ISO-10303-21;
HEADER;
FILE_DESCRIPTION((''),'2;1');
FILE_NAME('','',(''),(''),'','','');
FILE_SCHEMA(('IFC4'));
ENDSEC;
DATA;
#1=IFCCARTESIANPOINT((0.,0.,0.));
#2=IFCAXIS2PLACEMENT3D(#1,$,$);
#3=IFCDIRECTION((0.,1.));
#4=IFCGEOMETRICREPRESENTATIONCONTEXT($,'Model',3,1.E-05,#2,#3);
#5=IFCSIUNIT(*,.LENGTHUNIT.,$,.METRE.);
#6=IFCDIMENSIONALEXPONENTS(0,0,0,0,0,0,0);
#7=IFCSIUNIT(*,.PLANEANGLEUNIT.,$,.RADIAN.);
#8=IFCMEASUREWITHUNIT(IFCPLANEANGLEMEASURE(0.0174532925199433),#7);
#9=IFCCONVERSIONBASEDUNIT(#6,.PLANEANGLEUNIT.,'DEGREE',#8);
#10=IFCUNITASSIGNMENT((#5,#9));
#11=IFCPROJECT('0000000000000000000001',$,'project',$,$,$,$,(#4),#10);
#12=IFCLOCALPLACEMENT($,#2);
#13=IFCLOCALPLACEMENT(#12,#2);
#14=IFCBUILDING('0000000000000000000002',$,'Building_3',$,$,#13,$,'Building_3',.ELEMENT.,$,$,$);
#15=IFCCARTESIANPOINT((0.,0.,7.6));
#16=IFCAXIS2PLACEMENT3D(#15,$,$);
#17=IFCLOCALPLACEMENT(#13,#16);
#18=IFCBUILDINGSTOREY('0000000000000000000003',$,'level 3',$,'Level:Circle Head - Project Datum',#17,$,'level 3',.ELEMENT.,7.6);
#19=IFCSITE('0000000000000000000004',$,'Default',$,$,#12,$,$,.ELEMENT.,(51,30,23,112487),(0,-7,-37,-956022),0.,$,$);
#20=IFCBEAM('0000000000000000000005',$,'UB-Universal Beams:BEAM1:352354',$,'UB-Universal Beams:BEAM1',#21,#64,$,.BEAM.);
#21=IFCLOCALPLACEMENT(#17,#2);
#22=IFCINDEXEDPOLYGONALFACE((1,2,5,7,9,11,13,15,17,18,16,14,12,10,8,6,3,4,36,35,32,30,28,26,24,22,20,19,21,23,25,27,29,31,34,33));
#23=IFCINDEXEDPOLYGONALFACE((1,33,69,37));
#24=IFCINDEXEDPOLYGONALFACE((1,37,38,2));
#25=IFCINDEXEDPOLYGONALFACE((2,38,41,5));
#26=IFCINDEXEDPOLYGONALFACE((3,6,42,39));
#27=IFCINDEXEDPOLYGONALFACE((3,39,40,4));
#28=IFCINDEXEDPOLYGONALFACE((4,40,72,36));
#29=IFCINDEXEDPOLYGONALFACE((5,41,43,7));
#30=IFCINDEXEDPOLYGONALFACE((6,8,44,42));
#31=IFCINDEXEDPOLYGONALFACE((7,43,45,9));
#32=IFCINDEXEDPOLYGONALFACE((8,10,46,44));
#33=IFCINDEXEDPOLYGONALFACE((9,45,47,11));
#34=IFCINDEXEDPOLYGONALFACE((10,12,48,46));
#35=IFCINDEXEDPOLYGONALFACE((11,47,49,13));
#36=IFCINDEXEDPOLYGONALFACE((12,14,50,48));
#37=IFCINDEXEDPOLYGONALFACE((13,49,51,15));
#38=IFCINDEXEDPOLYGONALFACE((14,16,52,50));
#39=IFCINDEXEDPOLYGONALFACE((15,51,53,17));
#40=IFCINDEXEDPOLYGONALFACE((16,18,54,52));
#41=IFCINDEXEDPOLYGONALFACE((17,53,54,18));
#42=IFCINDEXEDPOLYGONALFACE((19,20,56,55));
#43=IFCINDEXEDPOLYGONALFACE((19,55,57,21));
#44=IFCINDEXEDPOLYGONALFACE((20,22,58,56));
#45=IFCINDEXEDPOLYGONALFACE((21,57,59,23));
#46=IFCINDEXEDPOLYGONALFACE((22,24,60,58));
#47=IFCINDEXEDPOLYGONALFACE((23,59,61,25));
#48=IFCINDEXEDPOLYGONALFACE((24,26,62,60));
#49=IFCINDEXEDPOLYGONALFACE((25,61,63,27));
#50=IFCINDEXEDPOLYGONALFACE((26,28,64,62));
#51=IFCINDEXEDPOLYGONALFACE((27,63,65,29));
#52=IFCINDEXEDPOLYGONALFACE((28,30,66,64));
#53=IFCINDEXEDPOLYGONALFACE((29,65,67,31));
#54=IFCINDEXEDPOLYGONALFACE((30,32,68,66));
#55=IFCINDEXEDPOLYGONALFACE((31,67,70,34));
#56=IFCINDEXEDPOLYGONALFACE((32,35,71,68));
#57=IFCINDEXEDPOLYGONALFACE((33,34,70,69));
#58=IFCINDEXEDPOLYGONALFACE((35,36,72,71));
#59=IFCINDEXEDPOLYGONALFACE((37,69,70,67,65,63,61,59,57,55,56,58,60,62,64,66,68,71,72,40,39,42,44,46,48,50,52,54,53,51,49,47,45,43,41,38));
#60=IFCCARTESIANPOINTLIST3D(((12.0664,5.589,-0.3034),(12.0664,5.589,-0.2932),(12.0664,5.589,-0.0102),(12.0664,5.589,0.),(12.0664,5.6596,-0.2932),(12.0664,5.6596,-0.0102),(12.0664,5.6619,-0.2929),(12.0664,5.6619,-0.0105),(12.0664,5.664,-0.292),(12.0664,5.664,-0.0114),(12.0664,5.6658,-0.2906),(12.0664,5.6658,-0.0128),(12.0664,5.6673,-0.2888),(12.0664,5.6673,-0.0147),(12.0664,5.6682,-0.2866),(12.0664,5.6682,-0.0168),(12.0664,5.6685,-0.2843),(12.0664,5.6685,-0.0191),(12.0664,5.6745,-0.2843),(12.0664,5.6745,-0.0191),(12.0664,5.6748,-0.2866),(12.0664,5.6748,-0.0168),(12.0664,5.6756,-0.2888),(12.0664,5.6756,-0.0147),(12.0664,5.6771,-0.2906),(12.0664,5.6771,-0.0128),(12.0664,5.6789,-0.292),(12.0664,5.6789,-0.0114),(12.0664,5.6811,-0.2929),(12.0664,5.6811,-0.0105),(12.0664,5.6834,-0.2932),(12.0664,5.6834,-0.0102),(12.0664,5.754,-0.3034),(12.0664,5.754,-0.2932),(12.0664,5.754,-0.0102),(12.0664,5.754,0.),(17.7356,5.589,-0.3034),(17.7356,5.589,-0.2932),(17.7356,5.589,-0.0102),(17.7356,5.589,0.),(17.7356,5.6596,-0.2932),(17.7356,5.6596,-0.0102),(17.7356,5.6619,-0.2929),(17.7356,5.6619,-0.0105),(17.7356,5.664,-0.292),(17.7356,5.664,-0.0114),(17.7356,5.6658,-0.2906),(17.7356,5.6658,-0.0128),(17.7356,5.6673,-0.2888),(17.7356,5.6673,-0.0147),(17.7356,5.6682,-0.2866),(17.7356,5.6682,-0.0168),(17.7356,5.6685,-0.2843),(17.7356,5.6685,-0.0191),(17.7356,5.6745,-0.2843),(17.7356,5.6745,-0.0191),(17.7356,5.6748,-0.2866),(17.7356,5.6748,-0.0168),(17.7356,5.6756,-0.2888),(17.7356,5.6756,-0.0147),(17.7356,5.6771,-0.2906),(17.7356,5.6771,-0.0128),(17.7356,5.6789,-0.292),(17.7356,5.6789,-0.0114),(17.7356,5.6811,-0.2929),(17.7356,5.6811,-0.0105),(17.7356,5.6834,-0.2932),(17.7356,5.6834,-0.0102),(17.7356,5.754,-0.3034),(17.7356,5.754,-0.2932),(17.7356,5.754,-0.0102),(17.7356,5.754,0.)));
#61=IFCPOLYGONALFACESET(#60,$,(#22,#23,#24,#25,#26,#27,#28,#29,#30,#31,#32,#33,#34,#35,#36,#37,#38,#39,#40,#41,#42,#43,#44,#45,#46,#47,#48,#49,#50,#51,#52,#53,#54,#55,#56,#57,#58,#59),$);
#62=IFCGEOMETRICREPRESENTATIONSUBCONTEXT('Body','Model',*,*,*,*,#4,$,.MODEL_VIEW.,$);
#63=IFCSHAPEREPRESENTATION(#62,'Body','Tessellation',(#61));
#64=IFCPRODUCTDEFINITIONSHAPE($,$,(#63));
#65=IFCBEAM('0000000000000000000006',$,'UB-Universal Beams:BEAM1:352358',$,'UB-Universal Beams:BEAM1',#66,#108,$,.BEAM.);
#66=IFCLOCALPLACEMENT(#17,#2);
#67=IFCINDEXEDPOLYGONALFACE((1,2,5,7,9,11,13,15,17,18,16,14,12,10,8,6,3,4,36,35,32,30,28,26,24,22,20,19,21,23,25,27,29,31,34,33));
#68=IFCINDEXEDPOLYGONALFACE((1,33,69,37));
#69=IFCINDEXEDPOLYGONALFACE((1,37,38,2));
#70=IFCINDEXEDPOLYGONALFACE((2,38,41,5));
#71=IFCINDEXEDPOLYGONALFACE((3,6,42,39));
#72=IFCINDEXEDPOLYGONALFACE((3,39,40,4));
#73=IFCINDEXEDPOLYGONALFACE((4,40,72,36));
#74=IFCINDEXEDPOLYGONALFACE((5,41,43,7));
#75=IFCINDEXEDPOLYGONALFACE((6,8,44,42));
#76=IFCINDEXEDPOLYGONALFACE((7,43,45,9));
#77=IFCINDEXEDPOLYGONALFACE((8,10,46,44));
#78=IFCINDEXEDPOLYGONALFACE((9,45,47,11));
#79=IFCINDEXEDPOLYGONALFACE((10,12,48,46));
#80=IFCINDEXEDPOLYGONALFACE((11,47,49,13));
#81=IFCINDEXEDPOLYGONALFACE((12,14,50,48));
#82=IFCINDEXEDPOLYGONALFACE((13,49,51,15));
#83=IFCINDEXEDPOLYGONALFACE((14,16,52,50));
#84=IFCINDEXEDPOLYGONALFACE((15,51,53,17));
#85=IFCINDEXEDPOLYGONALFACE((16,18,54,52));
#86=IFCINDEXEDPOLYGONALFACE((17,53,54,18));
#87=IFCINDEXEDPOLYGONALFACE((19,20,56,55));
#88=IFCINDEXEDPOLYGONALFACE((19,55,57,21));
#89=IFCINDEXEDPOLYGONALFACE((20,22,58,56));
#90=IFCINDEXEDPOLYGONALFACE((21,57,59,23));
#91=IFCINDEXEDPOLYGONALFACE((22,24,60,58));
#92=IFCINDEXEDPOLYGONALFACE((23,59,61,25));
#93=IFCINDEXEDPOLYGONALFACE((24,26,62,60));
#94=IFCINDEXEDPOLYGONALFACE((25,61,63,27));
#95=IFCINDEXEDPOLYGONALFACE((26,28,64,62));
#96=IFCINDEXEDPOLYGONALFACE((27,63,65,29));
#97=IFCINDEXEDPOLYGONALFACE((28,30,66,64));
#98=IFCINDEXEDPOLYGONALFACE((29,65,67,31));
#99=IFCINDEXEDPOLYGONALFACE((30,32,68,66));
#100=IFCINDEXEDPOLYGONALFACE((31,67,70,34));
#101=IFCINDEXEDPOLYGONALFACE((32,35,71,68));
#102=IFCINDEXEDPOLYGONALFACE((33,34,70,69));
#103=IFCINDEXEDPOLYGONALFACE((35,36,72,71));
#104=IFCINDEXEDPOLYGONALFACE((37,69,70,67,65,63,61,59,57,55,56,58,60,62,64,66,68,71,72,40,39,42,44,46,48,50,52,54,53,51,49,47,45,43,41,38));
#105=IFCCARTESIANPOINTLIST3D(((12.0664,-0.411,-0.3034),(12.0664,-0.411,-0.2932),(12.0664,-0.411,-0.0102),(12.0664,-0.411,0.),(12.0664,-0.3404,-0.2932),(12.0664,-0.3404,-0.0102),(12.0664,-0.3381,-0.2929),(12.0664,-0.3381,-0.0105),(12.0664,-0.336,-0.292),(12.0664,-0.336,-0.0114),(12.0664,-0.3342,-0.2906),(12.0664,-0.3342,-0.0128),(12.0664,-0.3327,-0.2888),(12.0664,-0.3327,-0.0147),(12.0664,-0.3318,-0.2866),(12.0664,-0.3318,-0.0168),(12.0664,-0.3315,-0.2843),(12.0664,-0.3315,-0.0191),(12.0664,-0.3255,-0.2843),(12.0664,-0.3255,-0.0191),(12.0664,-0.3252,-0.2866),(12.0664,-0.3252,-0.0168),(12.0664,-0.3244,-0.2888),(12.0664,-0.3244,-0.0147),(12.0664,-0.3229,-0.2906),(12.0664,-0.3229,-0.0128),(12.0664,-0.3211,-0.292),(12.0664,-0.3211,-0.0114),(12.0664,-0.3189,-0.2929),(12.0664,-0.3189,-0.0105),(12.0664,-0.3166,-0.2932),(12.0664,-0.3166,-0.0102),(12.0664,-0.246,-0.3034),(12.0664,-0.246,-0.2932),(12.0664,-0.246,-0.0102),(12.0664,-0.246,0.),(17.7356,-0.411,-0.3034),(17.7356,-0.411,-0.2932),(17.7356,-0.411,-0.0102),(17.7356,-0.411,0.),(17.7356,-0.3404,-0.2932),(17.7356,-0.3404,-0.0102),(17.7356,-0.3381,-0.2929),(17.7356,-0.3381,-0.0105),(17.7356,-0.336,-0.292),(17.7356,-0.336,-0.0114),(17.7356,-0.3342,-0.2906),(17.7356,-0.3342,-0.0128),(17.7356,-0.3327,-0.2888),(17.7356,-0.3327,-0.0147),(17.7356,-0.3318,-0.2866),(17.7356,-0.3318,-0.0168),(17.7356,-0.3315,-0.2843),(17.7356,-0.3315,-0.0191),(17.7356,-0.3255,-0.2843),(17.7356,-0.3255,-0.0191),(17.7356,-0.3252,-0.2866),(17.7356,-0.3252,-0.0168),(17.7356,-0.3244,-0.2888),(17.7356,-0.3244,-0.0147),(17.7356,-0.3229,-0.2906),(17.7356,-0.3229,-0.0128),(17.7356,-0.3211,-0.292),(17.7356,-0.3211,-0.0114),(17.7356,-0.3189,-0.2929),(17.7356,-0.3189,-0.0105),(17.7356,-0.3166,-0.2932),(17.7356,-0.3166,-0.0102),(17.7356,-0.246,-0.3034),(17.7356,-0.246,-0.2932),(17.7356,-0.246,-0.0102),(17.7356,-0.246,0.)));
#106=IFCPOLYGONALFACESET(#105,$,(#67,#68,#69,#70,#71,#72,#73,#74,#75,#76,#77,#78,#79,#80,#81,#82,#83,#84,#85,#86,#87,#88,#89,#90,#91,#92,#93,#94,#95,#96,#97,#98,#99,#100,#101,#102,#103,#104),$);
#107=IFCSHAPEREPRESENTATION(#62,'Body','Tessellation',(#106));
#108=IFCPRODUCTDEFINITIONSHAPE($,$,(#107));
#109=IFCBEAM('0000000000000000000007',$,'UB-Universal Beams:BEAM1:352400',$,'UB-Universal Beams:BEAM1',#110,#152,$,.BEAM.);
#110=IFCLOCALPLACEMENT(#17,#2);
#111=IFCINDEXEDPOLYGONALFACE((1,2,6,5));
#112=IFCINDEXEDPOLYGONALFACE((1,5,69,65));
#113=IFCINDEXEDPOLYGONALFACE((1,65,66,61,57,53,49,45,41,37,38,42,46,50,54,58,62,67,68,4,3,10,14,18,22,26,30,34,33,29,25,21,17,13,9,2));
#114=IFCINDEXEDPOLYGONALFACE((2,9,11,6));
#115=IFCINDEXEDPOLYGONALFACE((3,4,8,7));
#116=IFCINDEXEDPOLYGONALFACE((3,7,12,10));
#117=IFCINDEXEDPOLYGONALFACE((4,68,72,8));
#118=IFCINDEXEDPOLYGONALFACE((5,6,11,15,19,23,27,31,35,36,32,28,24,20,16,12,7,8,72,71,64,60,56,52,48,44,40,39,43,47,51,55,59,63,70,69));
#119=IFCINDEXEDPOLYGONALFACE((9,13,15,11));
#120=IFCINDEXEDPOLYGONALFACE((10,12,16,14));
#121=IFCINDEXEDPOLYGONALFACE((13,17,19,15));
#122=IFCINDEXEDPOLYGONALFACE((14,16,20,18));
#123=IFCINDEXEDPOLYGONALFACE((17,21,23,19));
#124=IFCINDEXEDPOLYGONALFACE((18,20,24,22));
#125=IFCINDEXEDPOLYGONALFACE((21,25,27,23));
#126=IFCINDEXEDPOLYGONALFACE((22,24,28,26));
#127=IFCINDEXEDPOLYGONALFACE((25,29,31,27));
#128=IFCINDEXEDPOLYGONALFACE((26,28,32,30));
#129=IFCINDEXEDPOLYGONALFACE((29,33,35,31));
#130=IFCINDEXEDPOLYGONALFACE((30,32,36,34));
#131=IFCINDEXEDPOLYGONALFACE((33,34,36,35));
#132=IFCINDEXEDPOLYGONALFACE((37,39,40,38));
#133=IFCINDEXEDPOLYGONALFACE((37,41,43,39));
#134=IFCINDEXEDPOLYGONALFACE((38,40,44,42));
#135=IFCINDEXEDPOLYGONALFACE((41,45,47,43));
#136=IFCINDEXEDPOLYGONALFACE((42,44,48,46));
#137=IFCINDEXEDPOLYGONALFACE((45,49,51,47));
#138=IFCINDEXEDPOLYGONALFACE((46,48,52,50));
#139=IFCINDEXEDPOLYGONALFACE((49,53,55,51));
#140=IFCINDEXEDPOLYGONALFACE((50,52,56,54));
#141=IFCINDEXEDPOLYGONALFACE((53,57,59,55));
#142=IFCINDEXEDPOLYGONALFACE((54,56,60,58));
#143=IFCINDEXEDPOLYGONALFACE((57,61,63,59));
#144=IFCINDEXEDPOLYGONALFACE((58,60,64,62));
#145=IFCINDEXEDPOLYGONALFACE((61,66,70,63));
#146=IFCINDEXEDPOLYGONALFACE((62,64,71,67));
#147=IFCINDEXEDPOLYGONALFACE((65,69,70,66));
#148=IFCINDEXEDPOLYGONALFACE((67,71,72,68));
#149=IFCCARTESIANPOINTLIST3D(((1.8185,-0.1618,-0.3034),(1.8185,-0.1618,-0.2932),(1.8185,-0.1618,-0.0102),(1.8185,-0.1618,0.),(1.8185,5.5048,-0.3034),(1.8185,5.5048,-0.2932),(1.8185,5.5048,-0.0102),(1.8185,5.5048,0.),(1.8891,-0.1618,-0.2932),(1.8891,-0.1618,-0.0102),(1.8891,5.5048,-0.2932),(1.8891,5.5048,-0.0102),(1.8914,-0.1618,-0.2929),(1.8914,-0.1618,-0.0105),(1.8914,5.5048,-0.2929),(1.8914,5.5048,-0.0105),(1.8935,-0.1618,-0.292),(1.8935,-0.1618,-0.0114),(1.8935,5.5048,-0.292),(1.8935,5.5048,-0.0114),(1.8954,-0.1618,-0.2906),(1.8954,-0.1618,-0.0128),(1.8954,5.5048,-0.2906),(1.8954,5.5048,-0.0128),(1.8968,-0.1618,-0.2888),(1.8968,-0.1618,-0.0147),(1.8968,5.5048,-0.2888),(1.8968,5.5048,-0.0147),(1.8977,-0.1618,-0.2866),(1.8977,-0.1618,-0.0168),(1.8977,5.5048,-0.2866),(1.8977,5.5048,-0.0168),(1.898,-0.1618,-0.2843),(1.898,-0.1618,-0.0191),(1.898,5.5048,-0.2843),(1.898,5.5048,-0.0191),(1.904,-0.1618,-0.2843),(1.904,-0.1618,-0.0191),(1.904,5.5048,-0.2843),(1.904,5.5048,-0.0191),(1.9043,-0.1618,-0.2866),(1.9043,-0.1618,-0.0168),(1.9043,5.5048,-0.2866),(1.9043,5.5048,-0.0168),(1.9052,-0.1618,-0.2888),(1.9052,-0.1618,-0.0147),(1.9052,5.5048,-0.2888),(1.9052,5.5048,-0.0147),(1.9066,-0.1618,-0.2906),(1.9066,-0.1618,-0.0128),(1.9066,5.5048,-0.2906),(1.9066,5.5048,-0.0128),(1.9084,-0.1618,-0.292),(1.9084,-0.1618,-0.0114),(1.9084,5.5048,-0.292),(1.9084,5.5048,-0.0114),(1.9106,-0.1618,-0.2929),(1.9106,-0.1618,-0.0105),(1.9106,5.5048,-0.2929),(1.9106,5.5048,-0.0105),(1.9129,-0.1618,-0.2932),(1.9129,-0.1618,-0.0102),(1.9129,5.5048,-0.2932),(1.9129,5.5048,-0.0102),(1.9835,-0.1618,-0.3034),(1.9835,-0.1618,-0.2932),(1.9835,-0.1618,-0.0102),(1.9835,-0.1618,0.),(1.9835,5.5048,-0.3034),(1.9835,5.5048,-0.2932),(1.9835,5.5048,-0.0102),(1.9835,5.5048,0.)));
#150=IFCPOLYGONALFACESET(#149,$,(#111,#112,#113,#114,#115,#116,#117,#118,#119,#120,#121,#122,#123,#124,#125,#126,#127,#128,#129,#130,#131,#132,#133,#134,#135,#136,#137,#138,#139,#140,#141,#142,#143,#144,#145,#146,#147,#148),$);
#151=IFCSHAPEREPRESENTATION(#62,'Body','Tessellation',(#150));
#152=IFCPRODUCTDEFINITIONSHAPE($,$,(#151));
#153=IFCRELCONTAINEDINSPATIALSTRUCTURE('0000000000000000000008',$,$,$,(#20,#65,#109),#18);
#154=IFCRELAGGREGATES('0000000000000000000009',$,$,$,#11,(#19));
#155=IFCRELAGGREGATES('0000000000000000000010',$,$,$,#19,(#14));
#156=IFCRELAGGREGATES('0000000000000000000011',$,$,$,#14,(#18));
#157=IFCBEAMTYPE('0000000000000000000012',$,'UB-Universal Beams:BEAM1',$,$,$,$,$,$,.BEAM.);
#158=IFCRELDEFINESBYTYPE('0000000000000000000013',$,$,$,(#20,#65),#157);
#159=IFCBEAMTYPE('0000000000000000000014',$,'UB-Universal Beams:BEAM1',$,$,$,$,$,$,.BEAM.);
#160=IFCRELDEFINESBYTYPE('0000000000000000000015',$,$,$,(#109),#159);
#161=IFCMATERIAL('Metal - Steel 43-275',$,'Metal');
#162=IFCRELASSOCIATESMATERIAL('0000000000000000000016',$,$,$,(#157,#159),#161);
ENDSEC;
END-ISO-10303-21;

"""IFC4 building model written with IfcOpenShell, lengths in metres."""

from ifc_helpers import new_model, entity, si_unit, converted_unit, direction, frame, frame_2d, origin, place, context, subcontext, project, spatial, polyline, circle_curve, parameter, trimmed, segment, composite_curve, outline, extrude, source, transform, mapped, material, material_profile, profile_set, type_object, type_shapes, element, save


model = new_model("IFC4")

# Units and contexts
model_context = context("Model", 3, precision=1e-05, world=origin(), true_north=direction((0.0, 1.0)))
body_context = subcontext(model_context, "Body", "Model", "MODEL_VIEW")
ifc_project = project(units=[si_unit("LENGTHUNIT", "METRE"), converted_unit("PLANEANGLEUNIT", "DEGREE", entity("IfcPlaneAngleMeasure", 0.0174532925199433), si_unit("PLANEANGLEUNIT", "RADIAN"), dimensions=[0, 0, 0, 0, 0, 0, 0])], contexts=[model_context])

# Site, building, storey
site_placement = place(None, origin())
site = spatial("IfcSite", under=ifc_project, at=site_placement, Name="Default", CompositionType="ELEMENT", RefLatitude=(51, 30, 23, 112487), RefLongitude=(0, -7, -37, -956022), RefElevation=0.0)
building_placement = place(site_placement, origin())
building = spatial("IfcBuilding", under=site, at=building_placement, Name="Building_3", LongName="Building_3", CompositionType="ELEMENT")
storey_placement = place(building_placement, frame((0.0, 0.0, 7.6)))
storey = spatial("IfcBuildingStorey", under=building, at=storey_placement, Name="level 3", ObjectType="Level:Circle Head - Project Datum", LongName="level 3", CompositionType="ELEMENT", Elevation=7.6)

# Shared definitions
ifc_material_1 = material(Name="Metal - Steel 43-275", Category="Metal")

# Beams
ifc_material_profile_1 = material_profile(ifc_material_1, outline(composite_curve([segment(polyline([(-0.0825, -0.1415), (-0.0825, -0.1517)]), True, "CONTINUOUS"), segment(polyline([(-0.0825, -0.1517), (0.0825, -0.1517)]), True, "CONTINUOUS"), segment(polyline([(0.0825, -0.1517), (0.0825, -0.1415)]), True, "CONTINUOUS"), segment(polyline([(0.0825, -0.1415), (0.0119, -0.1415)]), True, "CONTINUOUS"), segment(trimmed(circle_curve(frame_2d((0.0119, -0.1326), x_axis=(1.0, 0.0)), 0.0089), [parameter(180.0)], [parameter(270.0)], True, "PARAMETER"), False, "CONTINUOUS"), segment(polyline([(0.003, -0.1326), (0.003, 0.1326)]), True, "CONTINUOUS"), segment(trimmed(circle_curve(frame_2d((0.0119, 0.1326), x_axis=(1.0, 0.0)), 0.0089), [parameter(90.0)], [parameter(180.0)], True, "PARAMETER"), False, "CONTINUOUS"), segment(polyline([(0.0119, 0.1415), (0.0825, 0.1415)]), True, "CONTINUOUS"), segment(polyline([(0.0825, 0.1415), (0.0825, 0.1517)]), True, "CONTINUOUS"), segment(polyline([(0.0825, 0.1517), (-0.0825, 0.1517)]), True, "CONTINUOUS"), segment(polyline([(-0.0825, 0.1517), (-0.0825, 0.1415)]), True, "CONTINUOUS"), segment(polyline([(-0.0825, 0.1415), (-0.0119, 0.1415)]), True, "CONTINUOUS"), segment(trimmed(circle_curve(frame_2d((-0.0119, 0.1326), x_axis=(1.0, 0.0)), 0.0089), [parameter(360.0)], [parameter(90.0)], True, "PARAMETER"), False, "CONTINUOUS"), segment(polyline([(-0.003, 0.1326), (-0.003, -0.1326)]), True, "CONTINUOUS"), segment(trimmed(circle_curve(frame_2d((-0.0119, -0.1326), x_axis=(1.0, 0.0)), 0.0089), [parameter(270.0)], [parameter(360.0)], True, "PARAMETER"), False, "CONTINUOUS"), segment(polyline([(-0.0119, -0.1415), (-0.0825, -0.1415)]), True, "CONTINUOUS")], self_intersect=False)), Name="BEAM1")
ifc_profile_set_1 = profile_set([ifc_material_profile_1], Name="BEAM1")
beam_type_1 = type_object("IfcBeamType", Name="UB-Universal Beams:BEAM1", PredefinedType="BEAM", material=ifc_profile_set_1)
shared_shape_1 = source(origin(), body_context, "Body", "SweptSolid", [
    extrude(outline(composite_curve([segment(polyline([(-0.0825, -0.1415), (-0.0825, -0.1517)]), True, "CONTINUOUS"), segment(polyline([(-0.0825, -0.1517), (0.0825, -0.1517)]), True, "CONTINUOUS"), segment(polyline([(0.0825, -0.1517), (0.0825, -0.1415)]), True, "CONTINUOUS"), segment(polyline([(0.0825, -0.1415), (0.0119, -0.1415)]), True, "CONTINUOUS"), segment(trimmed(circle_curve(frame_2d((0.0119, -0.1326), x_axis=(0.0, -1.0)), 0.0089), [parameter(270.0)], [parameter(360.0)], True, "PARAMETER"), False, "CONTINUOUS"), segment(polyline([(0.003, -0.1326), (0.003, 0.1326)]), True, "CONTINUOUS"), segment(trimmed(circle_curve(frame_2d((0.0119, 0.1326), x_axis=(-1.0, 0.0)), 0.0089), [parameter(270.0)], [parameter(360.0)], True, "PARAMETER"), False, "CONTINUOUS"), segment(polyline([(0.0119, 0.1415), (0.0825, 0.1415)]), True, "CONTINUOUS"), segment(polyline([(0.0825, 0.1415), (0.0825, 0.1517)]), True, "CONTINUOUS"), segment(polyline([(0.0825, 0.1517), (-0.0825, 0.1517)]), True, "CONTINUOUS"), segment(polyline([(-0.0825, 0.1517), (-0.0825, 0.1415)]), True, "CONTINUOUS"), segment(polyline([(-0.0825, 0.1415), (-0.0119, 0.1415)]), True, "CONTINUOUS"), segment(trimmed(circle_curve(frame_2d((-0.0119, 0.1326), x_axis=(0.0, 1.0)), 0.0089), [parameter(270.0)], [parameter(360.0)], True, "PARAMETER"), False, "CONTINUOUS"), segment(polyline([(-0.003, 0.1326), (-0.003, -0.1326)]), True, "CONTINUOUS"), segment(trimmed(circle_curve(frame_2d((-0.0119, -0.1326), x_axis=(1.0, 0.0)), 0.0089), [parameter(270.0)], [parameter(0.0)], True, "PARAMETER"), False, "CONTINUOUS"), segment(polyline([(-0.0119, -0.1415), (-0.0825, -0.1415)]), True, "CONTINUOUS")], self_intersect=False)), frame((-2.8346, 0.0, 0.0), z_axis=(-1.0, 0.0, 0.0), x_axis=(0.0, -1.0, 0.0)), (0.0, 0.0, -1.0), 5.6692),
])
type_shapes(beam_type_1, [shared_shape_1])
for number, where, name in (
    (1, (14.901, 5.6715, -0.1517), "UB-Universal Beams:BEAM1:352354"),
    (2, (14.901, -0.3285, -0.1517), "UB-Universal Beams:BEAM1:352358"),
):
    element("IfcBeam", number, at=place(storey_placement, frame(where)), inside=storey, type_object=beam_type_1, Name=name, ObjectType="UB-Universal Beams:BEAM1", PredefinedType="BEAM", context=body_context, shape_type="MappedRepresentation", body=[
        mapped(shared_shape_1, transform((0.0, 0.0, 0.0), scale=1.0)),
    ])
beam_type_2 = type_object("IfcBeamType", Name="UB-Universal Beams:BEAM1", PredefinedType="BEAM", material=ifc_profile_set_1)
shared_shape_2 = source(origin(), body_context, "Body", "SweptSolid", [
    extrude(outline(composite_curve([segment(polyline([(-0.0825, -0.1415), (-0.0825, -0.1517)]), True, "CONTINUOUS"), segment(polyline([(-0.0825, -0.1517), (0.0825, -0.1517)]), True, "CONTINUOUS"), segment(polyline([(0.0825, -0.1517), (0.0825, -0.1415)]), True, "CONTINUOUS"), segment(polyline([(0.0825, -0.1415), (0.0119, -0.1415)]), True, "CONTINUOUS"), segment(trimmed(circle_curve(frame_2d((0.0119, -0.1326), x_axis=(1.0, 0.0)), 0.0089), [parameter(180.0)], [parameter(270.0)], True, "PARAMETER"), False, "CONTINUOUS"), segment(polyline([(0.003, -0.1326), (0.003, 0.1326)]), True, "CONTINUOUS"), segment(trimmed(circle_curve(frame_2d((0.0119, 0.1326), x_axis=(1.0, 0.0)), 0.0089), [parameter(90.0)], [parameter(180.0)], True, "PARAMETER"), False, "CONTINUOUS"), segment(polyline([(0.0119, 0.1415), (0.0825, 0.1415)]), True, "CONTINUOUS"), segment(polyline([(0.0825, 0.1415), (0.0825, 0.1517)]), True, "CONTINUOUS"), segment(polyline([(0.0825, 0.1517), (-0.0825, 0.1517)]), True, "CONTINUOUS"), segment(polyline([(-0.0825, 0.1517), (-0.0825, 0.1415)]), True, "CONTINUOUS"), segment(polyline([(-0.0825, 0.1415), (-0.0119, 0.1415)]), True, "CONTINUOUS"), segment(trimmed(circle_curve(frame_2d((-0.0119, 0.1326), x_axis=(1.0, 0.0)), 0.0089), [parameter(360.0)], [parameter(90.0)], True, "PARAMETER"), False, "CONTINUOUS"), segment(polyline([(-0.003, 0.1326), (-0.003, -0.1326)]), True, "CONTINUOUS"), segment(trimmed(circle_curve(frame_2d((-0.0119, -0.1326), x_axis=(1.0, 0.0)), 0.0089), [parameter(270.0)], [parameter(360.0)], True, "PARAMETER"), False, "CONTINUOUS"), segment(polyline([(-0.0119, -0.1415), (-0.0825, -0.1415)]), True, "CONTINUOUS")], self_intersect=False)), frame((-2.8333, 0.0, 0.0), z_axis=(-1.0, 0.0, 0.0), x_axis=(0.0, -1.0, 0.0)), (0.0, 0.0, -1.0), 5.6666),
])
type_shapes(beam_type_2, [shared_shape_2])
for number, where, z_axis, x_axis, name in (
    (3, (1.901, 2.6715, -0.1517), (0.0, 0.0, 1.0), (0.0, -1.0, 0.0), "UB-Universal Beams:BEAM1:352400"),
):
    element("IfcBeam", number, at=place(storey_placement, frame(where, z_axis=z_axis, x_axis=x_axis)), inside=storey, type_object=beam_type_2, Name=name, ObjectType="UB-Universal Beams:BEAM1", PredefinedType="BEAM", context=body_context, shape_type="MappedRepresentation", body=[
        mapped(shared_shape_2, transform((0.0, 0.0, 0.0), scale=1.0)),
    ])

save(model, "model.ifc")
